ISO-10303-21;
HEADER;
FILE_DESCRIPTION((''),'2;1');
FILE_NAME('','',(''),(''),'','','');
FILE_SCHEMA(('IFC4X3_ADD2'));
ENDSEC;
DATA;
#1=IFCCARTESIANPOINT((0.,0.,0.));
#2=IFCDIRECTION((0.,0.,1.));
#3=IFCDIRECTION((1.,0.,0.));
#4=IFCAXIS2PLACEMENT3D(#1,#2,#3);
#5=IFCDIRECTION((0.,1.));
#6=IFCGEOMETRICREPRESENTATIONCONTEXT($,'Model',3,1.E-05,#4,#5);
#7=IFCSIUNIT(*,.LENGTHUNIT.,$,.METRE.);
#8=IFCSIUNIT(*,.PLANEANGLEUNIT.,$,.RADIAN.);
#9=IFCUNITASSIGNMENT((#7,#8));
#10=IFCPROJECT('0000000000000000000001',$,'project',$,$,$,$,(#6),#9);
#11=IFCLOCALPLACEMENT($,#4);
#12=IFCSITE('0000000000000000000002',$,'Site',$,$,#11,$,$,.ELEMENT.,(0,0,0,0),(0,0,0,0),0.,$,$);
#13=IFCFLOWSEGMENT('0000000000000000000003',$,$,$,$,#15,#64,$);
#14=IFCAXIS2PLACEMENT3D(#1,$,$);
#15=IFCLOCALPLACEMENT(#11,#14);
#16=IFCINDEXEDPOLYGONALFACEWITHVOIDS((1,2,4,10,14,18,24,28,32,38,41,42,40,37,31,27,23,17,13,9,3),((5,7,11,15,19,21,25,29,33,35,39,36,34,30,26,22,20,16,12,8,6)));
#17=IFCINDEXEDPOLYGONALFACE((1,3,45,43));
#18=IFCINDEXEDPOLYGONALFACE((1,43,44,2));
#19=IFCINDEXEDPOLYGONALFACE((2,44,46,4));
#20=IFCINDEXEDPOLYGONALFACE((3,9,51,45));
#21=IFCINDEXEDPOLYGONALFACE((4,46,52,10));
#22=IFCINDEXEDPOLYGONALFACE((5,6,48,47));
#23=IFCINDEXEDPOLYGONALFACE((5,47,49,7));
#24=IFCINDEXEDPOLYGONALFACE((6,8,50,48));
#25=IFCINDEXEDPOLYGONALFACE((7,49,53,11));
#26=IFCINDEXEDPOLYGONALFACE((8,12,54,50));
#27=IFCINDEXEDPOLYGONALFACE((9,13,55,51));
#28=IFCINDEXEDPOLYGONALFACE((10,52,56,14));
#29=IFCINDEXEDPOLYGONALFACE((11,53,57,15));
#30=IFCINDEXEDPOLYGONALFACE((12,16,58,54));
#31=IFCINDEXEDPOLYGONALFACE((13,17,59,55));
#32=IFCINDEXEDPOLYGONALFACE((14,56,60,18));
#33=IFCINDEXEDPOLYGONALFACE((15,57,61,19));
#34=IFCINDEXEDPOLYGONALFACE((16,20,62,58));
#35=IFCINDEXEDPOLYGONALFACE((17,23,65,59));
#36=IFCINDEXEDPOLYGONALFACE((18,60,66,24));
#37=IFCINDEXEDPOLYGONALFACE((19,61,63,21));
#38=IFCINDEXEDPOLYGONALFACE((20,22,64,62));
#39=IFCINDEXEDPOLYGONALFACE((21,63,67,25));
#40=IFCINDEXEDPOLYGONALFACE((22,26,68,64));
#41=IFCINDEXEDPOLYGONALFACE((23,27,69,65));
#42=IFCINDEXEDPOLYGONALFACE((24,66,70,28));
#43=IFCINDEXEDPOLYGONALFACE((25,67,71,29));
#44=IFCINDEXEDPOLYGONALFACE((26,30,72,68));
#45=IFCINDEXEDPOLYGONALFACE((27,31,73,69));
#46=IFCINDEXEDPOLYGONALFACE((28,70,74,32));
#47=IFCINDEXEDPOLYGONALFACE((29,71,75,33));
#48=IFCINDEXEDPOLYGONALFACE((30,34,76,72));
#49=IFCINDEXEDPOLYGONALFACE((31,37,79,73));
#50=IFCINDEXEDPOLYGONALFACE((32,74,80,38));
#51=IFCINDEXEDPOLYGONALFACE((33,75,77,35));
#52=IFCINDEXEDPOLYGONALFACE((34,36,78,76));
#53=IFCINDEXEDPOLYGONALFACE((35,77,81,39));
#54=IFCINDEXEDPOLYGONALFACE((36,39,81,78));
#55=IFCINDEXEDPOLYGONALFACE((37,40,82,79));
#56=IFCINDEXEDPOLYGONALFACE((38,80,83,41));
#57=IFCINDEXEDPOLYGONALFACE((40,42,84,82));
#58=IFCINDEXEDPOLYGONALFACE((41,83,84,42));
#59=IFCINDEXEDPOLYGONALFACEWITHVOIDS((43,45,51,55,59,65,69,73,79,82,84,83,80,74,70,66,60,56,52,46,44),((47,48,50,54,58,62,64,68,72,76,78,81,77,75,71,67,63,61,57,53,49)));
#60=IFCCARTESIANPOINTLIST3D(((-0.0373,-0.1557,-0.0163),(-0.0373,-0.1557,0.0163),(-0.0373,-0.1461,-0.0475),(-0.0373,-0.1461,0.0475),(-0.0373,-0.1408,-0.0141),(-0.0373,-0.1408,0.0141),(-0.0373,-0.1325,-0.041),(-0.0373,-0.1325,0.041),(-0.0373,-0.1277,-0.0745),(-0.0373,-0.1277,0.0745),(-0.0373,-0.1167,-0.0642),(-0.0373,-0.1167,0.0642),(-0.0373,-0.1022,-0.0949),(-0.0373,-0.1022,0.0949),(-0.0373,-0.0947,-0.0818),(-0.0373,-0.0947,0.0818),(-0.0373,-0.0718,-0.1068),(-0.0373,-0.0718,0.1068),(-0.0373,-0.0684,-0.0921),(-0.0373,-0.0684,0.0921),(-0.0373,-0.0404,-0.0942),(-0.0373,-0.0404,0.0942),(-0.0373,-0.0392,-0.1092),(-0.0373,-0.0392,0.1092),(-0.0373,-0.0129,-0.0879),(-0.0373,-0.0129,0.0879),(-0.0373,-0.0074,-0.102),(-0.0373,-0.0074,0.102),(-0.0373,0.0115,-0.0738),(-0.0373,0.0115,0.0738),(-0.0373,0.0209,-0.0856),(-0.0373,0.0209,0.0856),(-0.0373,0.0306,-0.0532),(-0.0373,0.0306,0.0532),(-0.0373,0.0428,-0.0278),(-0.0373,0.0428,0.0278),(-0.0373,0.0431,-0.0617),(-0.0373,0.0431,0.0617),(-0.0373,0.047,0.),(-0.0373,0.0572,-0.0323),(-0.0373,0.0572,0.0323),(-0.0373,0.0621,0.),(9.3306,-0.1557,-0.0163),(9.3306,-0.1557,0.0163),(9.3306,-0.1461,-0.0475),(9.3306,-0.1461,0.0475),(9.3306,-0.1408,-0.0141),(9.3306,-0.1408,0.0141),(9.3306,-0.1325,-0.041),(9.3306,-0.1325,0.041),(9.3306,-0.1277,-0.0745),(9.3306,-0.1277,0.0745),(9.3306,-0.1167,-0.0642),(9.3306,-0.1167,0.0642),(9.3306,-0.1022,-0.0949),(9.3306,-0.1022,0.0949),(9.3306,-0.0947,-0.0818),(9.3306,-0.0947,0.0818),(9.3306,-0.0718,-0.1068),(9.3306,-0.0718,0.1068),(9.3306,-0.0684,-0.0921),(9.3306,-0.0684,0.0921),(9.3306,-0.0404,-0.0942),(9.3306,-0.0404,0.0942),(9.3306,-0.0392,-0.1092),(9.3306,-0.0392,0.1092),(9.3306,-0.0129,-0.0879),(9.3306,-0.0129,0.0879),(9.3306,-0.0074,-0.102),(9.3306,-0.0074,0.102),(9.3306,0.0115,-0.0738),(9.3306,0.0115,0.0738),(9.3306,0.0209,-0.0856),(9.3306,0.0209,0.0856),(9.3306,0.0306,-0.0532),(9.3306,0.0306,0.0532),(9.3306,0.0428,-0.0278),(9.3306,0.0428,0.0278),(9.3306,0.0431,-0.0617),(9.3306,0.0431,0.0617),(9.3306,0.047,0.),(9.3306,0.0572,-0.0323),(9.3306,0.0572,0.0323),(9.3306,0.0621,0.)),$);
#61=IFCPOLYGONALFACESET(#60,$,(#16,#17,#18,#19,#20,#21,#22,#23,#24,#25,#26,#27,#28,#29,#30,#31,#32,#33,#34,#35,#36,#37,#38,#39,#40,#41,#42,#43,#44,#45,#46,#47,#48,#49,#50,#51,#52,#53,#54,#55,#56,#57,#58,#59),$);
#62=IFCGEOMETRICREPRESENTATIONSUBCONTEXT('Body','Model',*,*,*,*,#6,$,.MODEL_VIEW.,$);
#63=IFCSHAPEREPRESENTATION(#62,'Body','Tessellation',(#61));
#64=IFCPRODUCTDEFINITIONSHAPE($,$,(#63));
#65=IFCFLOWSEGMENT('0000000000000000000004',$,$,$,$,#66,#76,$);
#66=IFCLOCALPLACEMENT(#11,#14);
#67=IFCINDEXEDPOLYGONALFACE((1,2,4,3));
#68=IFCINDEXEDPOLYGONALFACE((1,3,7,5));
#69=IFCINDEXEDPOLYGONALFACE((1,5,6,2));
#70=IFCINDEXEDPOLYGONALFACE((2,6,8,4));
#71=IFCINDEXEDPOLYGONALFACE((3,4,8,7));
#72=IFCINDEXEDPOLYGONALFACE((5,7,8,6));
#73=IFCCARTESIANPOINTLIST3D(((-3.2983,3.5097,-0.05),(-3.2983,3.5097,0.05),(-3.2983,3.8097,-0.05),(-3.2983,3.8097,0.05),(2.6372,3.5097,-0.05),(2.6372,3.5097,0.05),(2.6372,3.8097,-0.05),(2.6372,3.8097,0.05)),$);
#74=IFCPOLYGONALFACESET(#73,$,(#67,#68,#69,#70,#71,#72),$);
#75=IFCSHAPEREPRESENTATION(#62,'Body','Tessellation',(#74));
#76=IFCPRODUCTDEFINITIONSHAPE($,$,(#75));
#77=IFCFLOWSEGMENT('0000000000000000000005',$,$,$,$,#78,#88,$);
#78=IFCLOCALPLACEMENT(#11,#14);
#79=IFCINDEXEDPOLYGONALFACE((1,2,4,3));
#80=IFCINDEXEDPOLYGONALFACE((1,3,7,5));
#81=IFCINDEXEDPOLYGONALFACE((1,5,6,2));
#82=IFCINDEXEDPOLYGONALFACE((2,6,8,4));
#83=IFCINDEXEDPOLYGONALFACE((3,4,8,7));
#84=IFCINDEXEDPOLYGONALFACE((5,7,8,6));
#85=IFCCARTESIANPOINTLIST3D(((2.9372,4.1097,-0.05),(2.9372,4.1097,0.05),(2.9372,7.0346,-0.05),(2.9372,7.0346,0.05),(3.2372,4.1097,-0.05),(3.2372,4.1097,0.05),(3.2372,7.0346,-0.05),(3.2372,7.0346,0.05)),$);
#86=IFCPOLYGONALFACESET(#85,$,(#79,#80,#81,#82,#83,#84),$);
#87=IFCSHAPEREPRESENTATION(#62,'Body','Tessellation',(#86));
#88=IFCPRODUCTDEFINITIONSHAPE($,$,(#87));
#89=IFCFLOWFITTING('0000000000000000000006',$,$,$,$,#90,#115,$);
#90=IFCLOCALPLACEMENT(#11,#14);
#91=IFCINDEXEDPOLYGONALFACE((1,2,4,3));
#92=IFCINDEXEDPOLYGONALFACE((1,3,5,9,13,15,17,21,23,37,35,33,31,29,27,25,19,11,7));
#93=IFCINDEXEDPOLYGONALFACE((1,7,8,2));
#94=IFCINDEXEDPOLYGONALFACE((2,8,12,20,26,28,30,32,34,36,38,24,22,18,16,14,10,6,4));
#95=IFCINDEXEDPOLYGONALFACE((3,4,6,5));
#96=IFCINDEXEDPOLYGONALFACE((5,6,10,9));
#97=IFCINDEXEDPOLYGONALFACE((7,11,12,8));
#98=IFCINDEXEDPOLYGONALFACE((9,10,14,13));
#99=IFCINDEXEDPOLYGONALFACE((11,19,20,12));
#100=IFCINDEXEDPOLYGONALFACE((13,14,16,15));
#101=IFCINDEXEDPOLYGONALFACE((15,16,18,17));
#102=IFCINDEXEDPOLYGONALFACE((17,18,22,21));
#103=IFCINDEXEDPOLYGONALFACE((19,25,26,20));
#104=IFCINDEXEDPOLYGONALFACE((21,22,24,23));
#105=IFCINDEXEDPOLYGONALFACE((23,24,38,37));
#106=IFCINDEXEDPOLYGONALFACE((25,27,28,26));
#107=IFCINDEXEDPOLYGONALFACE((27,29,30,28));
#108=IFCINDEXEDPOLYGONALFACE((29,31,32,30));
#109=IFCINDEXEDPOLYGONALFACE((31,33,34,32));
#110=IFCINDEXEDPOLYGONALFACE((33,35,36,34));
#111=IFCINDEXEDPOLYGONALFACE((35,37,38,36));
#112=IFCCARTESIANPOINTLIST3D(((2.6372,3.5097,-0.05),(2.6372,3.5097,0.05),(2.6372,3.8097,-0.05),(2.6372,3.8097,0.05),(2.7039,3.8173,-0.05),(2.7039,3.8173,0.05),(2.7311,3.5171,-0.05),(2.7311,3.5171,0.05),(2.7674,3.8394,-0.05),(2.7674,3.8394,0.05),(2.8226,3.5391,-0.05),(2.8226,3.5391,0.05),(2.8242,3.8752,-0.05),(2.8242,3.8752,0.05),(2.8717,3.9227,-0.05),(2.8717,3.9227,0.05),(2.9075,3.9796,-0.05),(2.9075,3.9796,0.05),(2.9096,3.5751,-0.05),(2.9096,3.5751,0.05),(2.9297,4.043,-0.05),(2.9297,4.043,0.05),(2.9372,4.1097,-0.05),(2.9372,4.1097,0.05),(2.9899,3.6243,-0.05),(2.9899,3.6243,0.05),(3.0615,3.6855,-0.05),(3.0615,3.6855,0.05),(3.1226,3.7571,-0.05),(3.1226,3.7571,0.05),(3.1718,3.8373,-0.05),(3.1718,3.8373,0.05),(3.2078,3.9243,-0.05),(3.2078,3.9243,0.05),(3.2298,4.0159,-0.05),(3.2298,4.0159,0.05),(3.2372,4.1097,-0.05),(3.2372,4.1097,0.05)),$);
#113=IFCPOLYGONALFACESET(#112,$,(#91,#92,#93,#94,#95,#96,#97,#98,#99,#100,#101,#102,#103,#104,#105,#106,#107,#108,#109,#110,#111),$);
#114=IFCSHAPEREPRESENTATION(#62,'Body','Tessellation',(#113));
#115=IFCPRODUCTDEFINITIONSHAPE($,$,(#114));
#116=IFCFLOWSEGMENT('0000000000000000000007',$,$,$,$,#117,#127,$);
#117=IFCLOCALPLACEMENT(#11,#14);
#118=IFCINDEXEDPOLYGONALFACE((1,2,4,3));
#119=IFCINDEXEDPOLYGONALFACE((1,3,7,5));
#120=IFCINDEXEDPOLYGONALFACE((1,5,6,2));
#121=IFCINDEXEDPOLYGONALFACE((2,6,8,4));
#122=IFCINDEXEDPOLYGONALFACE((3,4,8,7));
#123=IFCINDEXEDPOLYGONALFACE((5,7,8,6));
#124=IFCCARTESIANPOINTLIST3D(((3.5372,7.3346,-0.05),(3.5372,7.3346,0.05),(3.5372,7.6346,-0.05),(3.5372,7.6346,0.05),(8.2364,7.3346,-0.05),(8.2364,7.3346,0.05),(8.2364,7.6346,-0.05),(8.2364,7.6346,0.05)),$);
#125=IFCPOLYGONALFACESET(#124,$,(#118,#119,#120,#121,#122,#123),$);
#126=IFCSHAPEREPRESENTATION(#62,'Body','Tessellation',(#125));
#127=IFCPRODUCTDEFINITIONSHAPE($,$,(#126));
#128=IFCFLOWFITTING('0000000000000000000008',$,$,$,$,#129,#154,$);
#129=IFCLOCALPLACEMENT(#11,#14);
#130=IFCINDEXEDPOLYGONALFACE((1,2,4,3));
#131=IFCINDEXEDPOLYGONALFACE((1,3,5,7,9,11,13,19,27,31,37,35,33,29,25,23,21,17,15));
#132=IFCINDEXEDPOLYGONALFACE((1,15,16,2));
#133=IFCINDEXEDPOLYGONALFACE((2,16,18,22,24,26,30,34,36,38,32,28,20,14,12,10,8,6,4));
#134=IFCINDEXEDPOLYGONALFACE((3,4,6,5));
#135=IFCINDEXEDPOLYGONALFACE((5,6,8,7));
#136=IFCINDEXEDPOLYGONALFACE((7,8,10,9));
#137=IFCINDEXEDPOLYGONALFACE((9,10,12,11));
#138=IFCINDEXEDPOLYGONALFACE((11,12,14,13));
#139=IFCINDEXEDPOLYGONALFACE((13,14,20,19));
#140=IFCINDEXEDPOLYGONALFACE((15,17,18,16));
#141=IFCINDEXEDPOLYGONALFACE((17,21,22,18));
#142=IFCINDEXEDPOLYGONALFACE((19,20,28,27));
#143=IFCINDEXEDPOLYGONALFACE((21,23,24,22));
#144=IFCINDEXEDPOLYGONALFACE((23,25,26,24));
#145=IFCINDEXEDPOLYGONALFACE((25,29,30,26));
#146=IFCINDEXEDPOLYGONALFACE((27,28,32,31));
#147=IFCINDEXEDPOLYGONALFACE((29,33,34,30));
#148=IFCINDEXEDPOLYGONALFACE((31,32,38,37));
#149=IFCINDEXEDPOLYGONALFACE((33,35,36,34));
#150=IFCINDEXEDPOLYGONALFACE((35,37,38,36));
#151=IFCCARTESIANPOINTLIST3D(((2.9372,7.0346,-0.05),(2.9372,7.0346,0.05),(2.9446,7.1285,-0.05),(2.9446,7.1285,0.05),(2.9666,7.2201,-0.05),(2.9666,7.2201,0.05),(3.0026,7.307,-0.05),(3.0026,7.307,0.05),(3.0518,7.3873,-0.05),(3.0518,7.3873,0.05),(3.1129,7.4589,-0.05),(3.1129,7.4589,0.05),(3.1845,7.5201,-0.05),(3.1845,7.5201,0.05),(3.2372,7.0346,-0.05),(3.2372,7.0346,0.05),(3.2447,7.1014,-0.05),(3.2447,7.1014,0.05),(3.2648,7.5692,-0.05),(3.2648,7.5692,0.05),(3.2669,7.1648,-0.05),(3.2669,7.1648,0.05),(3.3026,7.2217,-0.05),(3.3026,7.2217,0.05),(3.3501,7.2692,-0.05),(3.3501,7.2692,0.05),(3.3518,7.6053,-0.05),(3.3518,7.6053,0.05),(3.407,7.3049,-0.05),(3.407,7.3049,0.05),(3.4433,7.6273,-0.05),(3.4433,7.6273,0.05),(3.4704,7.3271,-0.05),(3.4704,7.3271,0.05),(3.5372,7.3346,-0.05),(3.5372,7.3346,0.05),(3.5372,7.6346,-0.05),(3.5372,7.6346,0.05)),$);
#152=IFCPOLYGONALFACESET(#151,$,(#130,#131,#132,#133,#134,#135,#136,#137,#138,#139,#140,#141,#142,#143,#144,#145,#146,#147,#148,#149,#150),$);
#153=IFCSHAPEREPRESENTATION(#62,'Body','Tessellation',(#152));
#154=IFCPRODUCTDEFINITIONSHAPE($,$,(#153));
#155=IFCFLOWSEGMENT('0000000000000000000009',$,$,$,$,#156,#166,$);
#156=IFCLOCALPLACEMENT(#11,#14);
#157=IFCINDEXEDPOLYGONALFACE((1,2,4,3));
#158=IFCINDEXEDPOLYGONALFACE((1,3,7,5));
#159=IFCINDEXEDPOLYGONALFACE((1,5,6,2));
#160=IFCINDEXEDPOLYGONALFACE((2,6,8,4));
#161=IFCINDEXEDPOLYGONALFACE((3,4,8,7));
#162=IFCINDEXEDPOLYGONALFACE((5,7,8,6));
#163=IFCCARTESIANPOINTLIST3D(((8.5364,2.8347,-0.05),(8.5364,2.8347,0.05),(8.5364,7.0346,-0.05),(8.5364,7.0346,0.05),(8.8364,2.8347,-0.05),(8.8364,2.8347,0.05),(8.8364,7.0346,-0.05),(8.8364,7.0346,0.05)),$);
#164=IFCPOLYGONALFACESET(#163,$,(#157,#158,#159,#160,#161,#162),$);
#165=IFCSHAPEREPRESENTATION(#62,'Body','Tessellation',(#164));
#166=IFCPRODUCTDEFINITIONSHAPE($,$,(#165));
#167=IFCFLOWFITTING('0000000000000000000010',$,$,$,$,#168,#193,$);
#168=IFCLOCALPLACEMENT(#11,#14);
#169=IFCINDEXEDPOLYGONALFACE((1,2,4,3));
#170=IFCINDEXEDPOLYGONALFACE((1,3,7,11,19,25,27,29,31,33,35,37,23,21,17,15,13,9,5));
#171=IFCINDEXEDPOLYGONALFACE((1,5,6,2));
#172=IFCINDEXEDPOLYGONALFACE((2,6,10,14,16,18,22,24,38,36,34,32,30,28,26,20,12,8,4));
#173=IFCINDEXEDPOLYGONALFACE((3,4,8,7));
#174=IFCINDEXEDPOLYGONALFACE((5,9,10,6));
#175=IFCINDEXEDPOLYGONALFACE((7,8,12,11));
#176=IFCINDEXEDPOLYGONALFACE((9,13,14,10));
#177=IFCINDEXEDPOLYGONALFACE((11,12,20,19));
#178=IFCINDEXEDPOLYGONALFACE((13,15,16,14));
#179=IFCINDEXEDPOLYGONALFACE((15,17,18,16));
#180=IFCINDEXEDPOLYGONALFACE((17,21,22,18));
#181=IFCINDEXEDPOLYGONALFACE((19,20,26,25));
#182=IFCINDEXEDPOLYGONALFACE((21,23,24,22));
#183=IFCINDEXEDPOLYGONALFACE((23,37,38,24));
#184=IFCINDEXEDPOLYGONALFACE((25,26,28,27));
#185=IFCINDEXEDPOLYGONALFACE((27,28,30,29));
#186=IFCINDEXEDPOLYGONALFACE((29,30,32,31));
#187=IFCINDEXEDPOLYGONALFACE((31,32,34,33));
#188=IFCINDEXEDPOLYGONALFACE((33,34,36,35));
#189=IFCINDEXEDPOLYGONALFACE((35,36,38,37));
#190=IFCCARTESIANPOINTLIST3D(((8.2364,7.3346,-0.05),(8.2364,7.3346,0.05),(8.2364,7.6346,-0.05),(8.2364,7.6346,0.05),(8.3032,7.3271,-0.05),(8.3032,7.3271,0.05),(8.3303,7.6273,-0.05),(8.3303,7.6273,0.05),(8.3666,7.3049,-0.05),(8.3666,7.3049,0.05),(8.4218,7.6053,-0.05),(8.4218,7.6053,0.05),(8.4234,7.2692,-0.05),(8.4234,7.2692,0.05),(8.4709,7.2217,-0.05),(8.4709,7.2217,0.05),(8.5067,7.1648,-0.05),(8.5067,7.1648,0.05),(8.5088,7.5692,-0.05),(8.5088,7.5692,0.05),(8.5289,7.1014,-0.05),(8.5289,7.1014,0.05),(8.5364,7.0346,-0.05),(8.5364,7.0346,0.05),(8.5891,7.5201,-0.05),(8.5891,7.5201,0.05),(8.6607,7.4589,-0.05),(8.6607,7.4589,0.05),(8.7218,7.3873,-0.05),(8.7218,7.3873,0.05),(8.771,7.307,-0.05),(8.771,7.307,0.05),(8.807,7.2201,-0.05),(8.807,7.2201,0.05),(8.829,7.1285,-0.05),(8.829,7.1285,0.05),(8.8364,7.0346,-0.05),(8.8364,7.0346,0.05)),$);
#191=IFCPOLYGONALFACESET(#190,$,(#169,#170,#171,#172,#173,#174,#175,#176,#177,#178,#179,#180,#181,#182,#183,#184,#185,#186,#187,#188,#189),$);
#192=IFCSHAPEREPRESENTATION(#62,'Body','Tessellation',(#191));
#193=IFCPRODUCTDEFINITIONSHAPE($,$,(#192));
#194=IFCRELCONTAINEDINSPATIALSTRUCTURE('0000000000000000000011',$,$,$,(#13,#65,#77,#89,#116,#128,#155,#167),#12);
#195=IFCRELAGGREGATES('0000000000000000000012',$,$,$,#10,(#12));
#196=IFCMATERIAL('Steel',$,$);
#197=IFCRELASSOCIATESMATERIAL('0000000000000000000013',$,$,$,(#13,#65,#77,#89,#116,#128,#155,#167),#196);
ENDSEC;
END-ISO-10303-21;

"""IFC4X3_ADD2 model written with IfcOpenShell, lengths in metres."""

from ifc_helpers import new_model, si_unit, point, direction, frame, origin_with_axes, origin_2d_with_axis, place, context, subcontext, project, spatial, polyline, circle_curve, trimmed, segment, composite_curve, rectangle, hollow_circle, outline, extrude, material, element, save


model = new_model("IFC4X3_ADD2")

# Units and contexts
model_context = context("Model", 3, precision=1e-05, world=origin_with_axes(), true_north=direction((0.0, 1.0)))
body_context = subcontext(model_context, "Body", "Model", "MODEL_VIEW")
ifc_project = project(units=[si_unit("LENGTHUNIT", "METRE"), si_unit("PLANEANGLEUNIT", "RADIAN")], contexts=[model_context])

# Site
site_placement = place(None, origin_with_axes())
site = spatial("IfcSite", under=ifc_project, at=site_placement, Name="Site", CompositionType="ELEMENT", RefLatitude=(0, 0, 0, 0), RefLongitude=(0, 0, 0, 0), RefElevation=0.0)

# Flow segments
ifc_material = material(Name="Steel")
flow_segment_1_placement = place(site_placement, frame((-0.0373, -0.0474, 0.0), z_axis=(1.0, 0.0, 0.0), x_axis=(0.0, 1.0, 0.0)))
element("IfcFlowSegment", 1, at=flow_segment_1_placement, inside=site, material=ifc_material, context=body_context, shape_type="SweptSolid", body=[
    extrude(hollow_circle(Radius=0.1095, WallThickness=0.0151, at=origin_2d_with_axis()), origin_with_axes(), (0.0, 0.0, 1.0), 9.368),
])
flow_segment_2_placement = place(site_placement, frame((-3.2983, 3.6597, 0.0), z_axis=(1.0, 0.0, 0.0), x_axis=(0.0, 1.0, 0.0)))
element("IfcFlowSegment", 2, at=flow_segment_2_placement, inside=site, material=ifc_material, context=body_context, shape_type="SweptSolid", body=[
    extrude(rectangle(XDim=0.3, YDim=0.1, at=origin_2d_with_axis()), origin_with_axes(), (0.0, 0.0, 1.0), 5.9355),
])
flow_segment_3_placement = place(site_placement, frame((3.0872, 4.1097, 0.0), z_axis=(0.0, 1.0, 0.0), x_axis=(-1.0, 0.0, 0.0)))
element("IfcFlowSegment", 3, at=flow_segment_3_placement, inside=site, material=ifc_material, context=body_context, shape_type="SweptSolid", body=[
    extrude(rectangle(XDim=0.3, YDim=0.1, at=origin_2d_with_axis()), origin_with_axes(), (0.0, 0.0, 1.0), 2.9249),
])

# Flow fitting
flow_fitting_1_placement = place(site_placement, frame((2.6372, 4.1097, -0.05), z_axis=(0.0, 0.0, 1.0), x_axis=(0.0, -1.0, 0.0)))
element("IfcFlowFitting", 4, at=flow_fitting_1_placement, inside=site, material=ifc_material, context=body_context, shape_type="SweptSolid", body=[
    extrude(outline(composite_curve([segment(polyline([(0.0, 0.3), (0.0, 0.6)]), True, "CONTINUOUS"), segment(trimmed(circle_curve(origin_2d_with_axis(), 0.6), [point((0.0, 0.6))], [point((0.6, 0.0))], False, "CARTESIAN"), True, "CONTINUOUS"), segment(polyline([(0.6, 0.0), (0.3, 0.0)]), True, "CONTINUOUS"), segment(trimmed(circle_curve(origin_2d_with_axis(), 0.3), [point((0.3, 0.0))], [point((0.0, 0.3))], True, "CARTESIAN"), True, "CONTINUOUS")], self_intersect=False)), origin_with_axes(), (0.0, 0.0, 1.0), 0.1),
])

# Flow segment
flow_segment_4_placement = place(site_placement, frame((3.5372, 7.4846, 0.0), z_axis=(1.0, 0.0, 0.0), x_axis=(0.0, 1.0, 0.0)))
element("IfcFlowSegment", 5, at=flow_segment_4_placement, inside=site, material=ifc_material, context=body_context, shape_type="SweptSolid", body=[
    extrude(rectangle(XDim=0.3, YDim=0.1, at=origin_2d_with_axis()), origin_with_axes(), (0.0, 0.0, 1.0), 4.6992),
])

# Flow fitting
flow_fitting_2_placement = place(site_placement, frame((2.9372, 7.0346, -0.05), z_axis=(0.0, 0.0, 1.0), x_axis=(1.0, 0.0, 0.0)))
element("IfcFlowFitting", 6, at=flow_fitting_2_placement, inside=site, material=ifc_material, context=body_context, shape_type="SweptSolid", body=[
    extrude(outline(composite_curve([segment(polyline([(0.0, 0.6), (0.0, 0.3)]), True, "CONTINUOUS"), segment(trimmed(circle_curve(origin_2d_with_axis(), 0.3), [point((0.0, 0.3))], [point((-0.3, 0.0))], True, "CARTESIAN"), True, "CONTINUOUS"), segment(polyline([(-0.3, 0.0), (-0.6, 0.0)]), True, "CONTINUOUS"), segment(trimmed(circle_curve(origin_2d_with_axis(), 0.6), [point((-0.6, 0.0))], [point((0.0, 0.6))], False, "CARTESIAN"), True, "CONTINUOUS")], self_intersect=False)), frame((0.6, 0.0, 0.0), z_axis=(0.0, 0.0, 1.0), x_axis=(1.0, 0.0, 0.0)), (0.0, 0.0, 1.0), 0.1),
])

# Flow segment
flow_segment_5_placement = place(site_placement, frame((8.6864, 7.0346, 0.0), z_axis=(0.0, -1.0, 0.0), x_axis=(1.0, 0.0, 0.0)))
element("IfcFlowSegment", 7, at=flow_segment_5_placement, inside=site, material=ifc_material, context=body_context, shape_type="SweptSolid", body=[
    extrude(rectangle(XDim=0.3, YDim=0.1, at=origin_2d_with_axis()), origin_with_axes(), (0.0, 0.0, 1.0), 4.2),
])

# Flow fitting
flow_fitting_3_placement = place(site_placement, frame((8.2364, 7.0346, -0.05), z_axis=(0.0, 0.0, 1.0), x_axis=(1.0, 0.0, 0.0)))
element("IfcFlowFitting", 8, at=flow_fitting_3_placement, inside=site, material=ifc_material, context=body_context, shape_type="SweptSolid", body=[
    extrude(outline(composite_curve([segment(polyline([(0.6, 0.0), (0.3, 0.0)]), True, "CONTINUOUS"), segment(trimmed(circle_curve(origin_2d_with_axis(), 0.3), [point((0.3, 0.0))], [point((0.0, 0.3))], True, "CARTESIAN"), True, "CONTINUOUS"), segment(polyline([(0.0, 0.3), (0.0, 0.6)]), True, "CONTINUOUS"), segment(trimmed(circle_curve(origin_2d_with_axis(), 0.6), [point((0.0, 0.6))], [point((0.6, 0.0))], False, "CARTESIAN"), True, "CONTINUOUS")], self_intersect=False)), origin_with_axes(), (0.0, 0.0, 1.0), 0.1),
])

save(model, "model.ifc")
